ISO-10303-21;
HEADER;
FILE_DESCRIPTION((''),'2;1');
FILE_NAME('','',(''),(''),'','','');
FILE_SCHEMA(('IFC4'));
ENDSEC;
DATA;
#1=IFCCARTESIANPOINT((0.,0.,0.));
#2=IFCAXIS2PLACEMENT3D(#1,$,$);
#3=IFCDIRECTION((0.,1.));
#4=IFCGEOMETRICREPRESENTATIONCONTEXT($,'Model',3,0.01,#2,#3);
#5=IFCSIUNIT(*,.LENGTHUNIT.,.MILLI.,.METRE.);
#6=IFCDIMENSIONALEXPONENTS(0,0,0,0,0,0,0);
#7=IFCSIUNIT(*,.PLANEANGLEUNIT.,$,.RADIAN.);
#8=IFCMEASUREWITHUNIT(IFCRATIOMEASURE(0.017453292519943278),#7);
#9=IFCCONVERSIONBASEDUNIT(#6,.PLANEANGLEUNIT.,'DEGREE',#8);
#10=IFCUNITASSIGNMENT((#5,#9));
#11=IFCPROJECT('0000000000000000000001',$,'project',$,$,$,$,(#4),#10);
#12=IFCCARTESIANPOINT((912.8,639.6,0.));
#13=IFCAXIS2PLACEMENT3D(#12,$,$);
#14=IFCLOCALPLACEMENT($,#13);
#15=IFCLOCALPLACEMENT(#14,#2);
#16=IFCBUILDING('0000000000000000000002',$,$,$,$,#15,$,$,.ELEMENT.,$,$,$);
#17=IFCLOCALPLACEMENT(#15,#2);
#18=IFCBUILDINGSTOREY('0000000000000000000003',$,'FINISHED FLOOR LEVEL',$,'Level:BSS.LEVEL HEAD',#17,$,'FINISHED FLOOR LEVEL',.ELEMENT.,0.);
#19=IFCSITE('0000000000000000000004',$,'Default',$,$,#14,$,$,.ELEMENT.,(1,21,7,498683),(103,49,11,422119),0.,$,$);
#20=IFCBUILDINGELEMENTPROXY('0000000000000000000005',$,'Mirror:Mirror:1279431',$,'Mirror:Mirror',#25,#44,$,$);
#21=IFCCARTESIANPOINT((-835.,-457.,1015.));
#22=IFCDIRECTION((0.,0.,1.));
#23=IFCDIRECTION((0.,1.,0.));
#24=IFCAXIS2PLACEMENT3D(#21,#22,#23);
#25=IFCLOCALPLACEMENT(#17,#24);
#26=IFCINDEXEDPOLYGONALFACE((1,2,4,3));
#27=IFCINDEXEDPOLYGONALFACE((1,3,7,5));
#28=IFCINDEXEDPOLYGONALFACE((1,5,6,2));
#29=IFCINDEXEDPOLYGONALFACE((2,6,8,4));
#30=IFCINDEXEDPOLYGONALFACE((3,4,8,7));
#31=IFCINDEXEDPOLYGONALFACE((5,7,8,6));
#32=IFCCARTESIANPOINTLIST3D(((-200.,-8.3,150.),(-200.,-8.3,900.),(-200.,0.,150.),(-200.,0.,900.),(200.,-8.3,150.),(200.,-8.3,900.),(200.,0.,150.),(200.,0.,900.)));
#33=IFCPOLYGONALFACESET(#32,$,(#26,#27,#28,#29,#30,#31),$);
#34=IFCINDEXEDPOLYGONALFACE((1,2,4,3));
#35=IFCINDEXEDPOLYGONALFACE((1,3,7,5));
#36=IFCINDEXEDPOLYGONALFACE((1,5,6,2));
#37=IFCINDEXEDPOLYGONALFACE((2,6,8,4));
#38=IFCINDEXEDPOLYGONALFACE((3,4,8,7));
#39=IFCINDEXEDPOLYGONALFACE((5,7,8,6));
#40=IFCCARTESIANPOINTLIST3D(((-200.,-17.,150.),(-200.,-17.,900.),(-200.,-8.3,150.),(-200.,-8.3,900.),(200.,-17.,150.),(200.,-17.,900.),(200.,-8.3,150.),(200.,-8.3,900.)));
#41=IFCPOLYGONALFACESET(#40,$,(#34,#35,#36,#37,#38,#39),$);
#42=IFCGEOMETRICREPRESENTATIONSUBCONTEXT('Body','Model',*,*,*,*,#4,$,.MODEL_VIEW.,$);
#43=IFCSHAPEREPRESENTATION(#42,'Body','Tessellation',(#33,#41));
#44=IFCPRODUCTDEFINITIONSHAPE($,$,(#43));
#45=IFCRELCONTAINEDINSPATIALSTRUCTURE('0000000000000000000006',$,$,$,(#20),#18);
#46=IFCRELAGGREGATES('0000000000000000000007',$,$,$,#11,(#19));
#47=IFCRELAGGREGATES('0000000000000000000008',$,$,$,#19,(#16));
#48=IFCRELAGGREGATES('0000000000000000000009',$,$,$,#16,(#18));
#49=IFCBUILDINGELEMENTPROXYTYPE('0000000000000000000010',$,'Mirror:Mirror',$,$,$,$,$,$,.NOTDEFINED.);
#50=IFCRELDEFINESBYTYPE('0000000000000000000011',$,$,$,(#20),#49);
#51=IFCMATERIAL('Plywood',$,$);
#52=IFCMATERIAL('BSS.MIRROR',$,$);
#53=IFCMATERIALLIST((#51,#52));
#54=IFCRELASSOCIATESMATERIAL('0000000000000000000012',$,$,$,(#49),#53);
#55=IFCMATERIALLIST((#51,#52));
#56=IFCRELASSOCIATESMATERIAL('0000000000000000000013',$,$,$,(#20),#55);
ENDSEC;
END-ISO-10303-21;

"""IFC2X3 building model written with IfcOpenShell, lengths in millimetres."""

from ifc_helpers import new_model, entity, si_unit, converted_unit, direction, frame, origin, origin_2d_with_axis, place, context, subcontext, project, spatial, rectangle, extrude, source, transform, mapped, material, material_list, type_object, type_shapes, element, save


model = new_model("IFC2X3")

# Units and contexts
model_context = context("Model", 3, precision=0.01, world=origin(), true_north=direction((0.0, 1.0)))
body_context = subcontext(model_context, "Body", "Model", "MODEL_VIEW")
ifc_project = project(units=[si_unit("LENGTHUNIT", "METRE", prefix="MILLI"), converted_unit("PLANEANGLEUNIT", "DEGREE", entity("IfcRatioMeasure", 0.017453292519943278), si_unit("PLANEANGLEUNIT", "RADIAN"), dimensions=[0, 0, 0, 0, 0, 0, 0])], contexts=[model_context])

# Site, building, storey
site_placement = place(None, frame((912.8, 639.6, 0.0)))
site = spatial("IfcSite", under=ifc_project, at=site_placement, Name="Default", CompositionType="ELEMENT", RefLatitude=(1, 21, 7, 498683), RefLongitude=(103, 49, 11, 422119), RefElevation=0.0)
building_placement = place(site_placement, origin())
building = spatial("IfcBuilding", under=site, at=building_placement, CompositionType="ELEMENT")
storey_placement = place(building_placement, origin())
storey = spatial("IfcBuildingStorey", under=building, at=storey_placement, Name="FINISHED FLOOR LEVEL", ObjectType="Level:BSS.LEVEL HEAD", LongName="FINISHED FLOOR LEVEL", CompositionType="ELEMENT", Elevation=0.0)

# Building element proxy
ifc_material_1 = material(Name="Plywood")
ifc_material_2 = material(Name="BSS.MIRROR")
ifc_material_list_1 = material_list([ifc_material_1, ifc_material_2])
ifc_material_list_2 = material_list([ifc_material_1, ifc_material_2])
building_element_proxy_type = type_object("IfcBuildingElementProxyType", Name="Mirror:Mirror", PredefinedType="NOTDEFINED", material=ifc_material_list_2)
shared_shape = source(origin(), body_context, "Body", "SweptSolid", [
    extrude(rectangle(XDim=8.3, YDim=400.0, at=origin_2d_with_axis()), frame((0.0, -4.1, 150.0), z_axis=(0.0, 0.0, 1.0), x_axis=(0.0, 1.0, 0.0)), (0.0, 0.0, 1.0), 750.0),
    extrude(rectangle(XDim=8.7, YDim=400.0, at=origin_2d_with_axis()), frame((0.0, -12.6, 150.0), z_axis=(0.0, 0.0, 1.0), x_axis=(0.0, 1.0, 0.0)), (0.0, 0.0, 1.0), 750.0),
])
type_shapes(building_element_proxy_type, [shared_shape])
proxy_placement = place(storey_placement, frame((-835.0, -457.0, 1015.0), z_axis=(0.0, 0.0, 1.0), x_axis=(0.0, 1.0, 0.0)))
element("IfcBuildingElementProxy", 1, at=proxy_placement, inside=storey, type_object=building_element_proxy_type, material=ifc_material_list_1, Name="Mirror:Mirror:1279431", ObjectType="Mirror:Mirror", context=body_context, shape_type="MappedRepresentation", body=[
    mapped(shared_shape, transform((0.0, 0.0, 0.0), scale=1.0)),
])

save(model, "model.ifc")
